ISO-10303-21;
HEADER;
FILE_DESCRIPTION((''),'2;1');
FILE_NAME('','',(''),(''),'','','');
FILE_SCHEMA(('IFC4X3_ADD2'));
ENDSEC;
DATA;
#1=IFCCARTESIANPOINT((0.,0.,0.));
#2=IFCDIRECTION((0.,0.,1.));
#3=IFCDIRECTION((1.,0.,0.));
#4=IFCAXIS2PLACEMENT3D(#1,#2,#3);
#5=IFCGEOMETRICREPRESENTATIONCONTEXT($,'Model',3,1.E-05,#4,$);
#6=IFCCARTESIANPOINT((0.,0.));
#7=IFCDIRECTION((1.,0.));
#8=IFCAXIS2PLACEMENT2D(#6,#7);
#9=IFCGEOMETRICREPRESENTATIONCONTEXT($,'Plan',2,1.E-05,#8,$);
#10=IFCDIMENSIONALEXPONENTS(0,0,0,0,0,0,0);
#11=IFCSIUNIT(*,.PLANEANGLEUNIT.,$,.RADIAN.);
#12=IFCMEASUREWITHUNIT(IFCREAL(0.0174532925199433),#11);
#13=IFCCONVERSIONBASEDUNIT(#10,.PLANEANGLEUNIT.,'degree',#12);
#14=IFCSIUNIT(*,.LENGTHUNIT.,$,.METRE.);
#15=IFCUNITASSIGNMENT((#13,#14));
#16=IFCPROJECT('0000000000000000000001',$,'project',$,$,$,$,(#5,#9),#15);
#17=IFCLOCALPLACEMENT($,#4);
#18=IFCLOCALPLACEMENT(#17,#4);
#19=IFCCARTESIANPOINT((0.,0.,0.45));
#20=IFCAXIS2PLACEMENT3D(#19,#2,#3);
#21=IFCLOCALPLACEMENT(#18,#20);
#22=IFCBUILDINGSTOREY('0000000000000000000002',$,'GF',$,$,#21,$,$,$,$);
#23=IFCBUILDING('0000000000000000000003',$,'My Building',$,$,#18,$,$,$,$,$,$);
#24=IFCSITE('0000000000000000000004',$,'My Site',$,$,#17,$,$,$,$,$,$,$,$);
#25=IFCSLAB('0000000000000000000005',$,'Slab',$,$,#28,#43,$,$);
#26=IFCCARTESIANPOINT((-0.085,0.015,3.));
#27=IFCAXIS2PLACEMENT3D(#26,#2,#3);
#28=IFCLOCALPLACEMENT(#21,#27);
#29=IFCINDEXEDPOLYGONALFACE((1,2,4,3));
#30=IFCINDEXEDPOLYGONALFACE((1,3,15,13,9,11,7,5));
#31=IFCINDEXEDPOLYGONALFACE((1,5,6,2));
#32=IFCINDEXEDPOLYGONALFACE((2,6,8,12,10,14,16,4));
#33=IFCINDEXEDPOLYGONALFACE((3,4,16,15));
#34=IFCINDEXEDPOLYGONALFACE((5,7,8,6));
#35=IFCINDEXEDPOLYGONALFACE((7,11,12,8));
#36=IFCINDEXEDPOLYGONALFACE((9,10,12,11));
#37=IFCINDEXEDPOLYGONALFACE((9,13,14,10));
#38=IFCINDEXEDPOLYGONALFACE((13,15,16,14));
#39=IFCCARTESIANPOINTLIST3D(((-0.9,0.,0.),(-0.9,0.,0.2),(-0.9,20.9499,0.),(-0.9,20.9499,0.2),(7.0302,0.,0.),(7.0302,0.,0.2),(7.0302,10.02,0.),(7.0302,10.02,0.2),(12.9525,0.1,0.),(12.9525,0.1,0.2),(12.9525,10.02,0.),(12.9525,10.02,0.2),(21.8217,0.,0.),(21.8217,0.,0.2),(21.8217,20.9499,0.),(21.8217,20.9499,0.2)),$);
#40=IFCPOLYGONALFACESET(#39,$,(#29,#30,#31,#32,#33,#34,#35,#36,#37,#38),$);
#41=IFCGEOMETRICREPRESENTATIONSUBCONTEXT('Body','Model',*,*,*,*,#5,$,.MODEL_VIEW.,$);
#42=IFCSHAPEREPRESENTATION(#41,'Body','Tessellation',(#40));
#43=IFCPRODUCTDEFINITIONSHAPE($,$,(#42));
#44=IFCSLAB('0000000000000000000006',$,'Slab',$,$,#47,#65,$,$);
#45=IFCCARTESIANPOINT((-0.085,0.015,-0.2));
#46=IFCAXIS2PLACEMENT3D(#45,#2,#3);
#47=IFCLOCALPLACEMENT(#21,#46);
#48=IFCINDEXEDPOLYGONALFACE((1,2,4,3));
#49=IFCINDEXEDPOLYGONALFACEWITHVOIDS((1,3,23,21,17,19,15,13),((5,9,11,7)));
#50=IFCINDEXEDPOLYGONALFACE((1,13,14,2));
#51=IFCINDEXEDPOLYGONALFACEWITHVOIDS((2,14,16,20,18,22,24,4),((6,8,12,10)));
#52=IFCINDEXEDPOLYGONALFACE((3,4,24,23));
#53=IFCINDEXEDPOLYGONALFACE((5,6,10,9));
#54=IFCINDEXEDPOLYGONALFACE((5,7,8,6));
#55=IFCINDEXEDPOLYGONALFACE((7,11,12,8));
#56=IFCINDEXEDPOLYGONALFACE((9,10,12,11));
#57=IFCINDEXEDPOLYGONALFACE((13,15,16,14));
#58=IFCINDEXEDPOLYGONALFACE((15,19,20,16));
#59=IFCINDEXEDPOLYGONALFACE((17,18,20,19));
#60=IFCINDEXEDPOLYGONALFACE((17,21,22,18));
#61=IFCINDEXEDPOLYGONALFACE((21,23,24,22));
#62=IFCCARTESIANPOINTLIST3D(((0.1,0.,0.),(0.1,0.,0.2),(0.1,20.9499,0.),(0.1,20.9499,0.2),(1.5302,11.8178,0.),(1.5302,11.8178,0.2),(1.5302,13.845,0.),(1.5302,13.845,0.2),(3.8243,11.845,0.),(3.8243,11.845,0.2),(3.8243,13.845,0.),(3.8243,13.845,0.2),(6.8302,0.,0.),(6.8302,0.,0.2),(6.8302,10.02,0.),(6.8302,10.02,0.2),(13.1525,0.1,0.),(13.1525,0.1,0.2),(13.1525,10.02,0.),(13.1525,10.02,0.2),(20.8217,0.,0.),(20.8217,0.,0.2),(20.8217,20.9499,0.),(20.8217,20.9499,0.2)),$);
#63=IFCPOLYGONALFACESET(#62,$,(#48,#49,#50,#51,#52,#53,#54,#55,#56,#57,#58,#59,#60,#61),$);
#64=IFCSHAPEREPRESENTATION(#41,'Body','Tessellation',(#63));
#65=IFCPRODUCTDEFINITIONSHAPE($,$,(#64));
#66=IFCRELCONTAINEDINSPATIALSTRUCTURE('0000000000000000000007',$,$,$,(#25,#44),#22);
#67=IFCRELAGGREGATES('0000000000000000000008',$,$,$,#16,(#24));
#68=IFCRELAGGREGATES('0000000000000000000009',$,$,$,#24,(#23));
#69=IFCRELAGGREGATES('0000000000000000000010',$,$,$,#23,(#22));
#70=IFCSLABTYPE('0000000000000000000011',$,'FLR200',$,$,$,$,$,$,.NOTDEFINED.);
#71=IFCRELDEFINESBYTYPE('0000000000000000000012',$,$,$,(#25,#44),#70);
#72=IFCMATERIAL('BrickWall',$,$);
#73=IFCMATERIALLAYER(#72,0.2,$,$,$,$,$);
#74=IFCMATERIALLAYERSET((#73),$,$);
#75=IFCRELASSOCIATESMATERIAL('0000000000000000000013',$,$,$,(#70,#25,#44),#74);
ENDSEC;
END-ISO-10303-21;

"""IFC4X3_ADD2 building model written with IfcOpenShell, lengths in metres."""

from ifc_helpers import new_model, entity, si_unit, converted_unit, frame, origin_with_axes, origin_2d_with_axis, place, context, subcontext, project, spatial, line, indexed_curve, outline, extrude, material, layer, layer_set, layer_usage, type_object, element, save


model = new_model("IFC4X3_ADD2")

# Units and contexts
model_context = context("Model", 3, precision=1e-05, world=origin_with_axes())
plan_context = context("Plan", 2, precision=1e-05, world=origin_2d_with_axis())
body_context_1 = subcontext(model_context, "Body", "Model", "MODEL_VIEW")
ifc_project = project(units=[converted_unit("PLANEANGLEUNIT", "degree", entity("IfcReal", 0.0174532925199433), si_unit("PLANEANGLEUNIT", "RADIAN"), dimensions=[0, 0, 0, 0, 0, 0, 0]), si_unit("LENGTHUNIT", "METRE")], contexts=[model_context, plan_context])

# Site, building, storey
site_placement = place(None, origin_with_axes())
site = spatial("IfcSite", under=ifc_project, at=site_placement, Name="My Site")
building_placement = place(site_placement, origin_with_axes())
building = spatial("IfcBuilding", under=site, at=building_placement, Name="My Building")
storey_placement = place(building_placement, frame((0.0, 0.0, 0.45), z_axis=(0.0, 0.0, 1.0), x_axis=(1.0, 0.0, 0.0)))
storey = spatial("IfcBuildingStorey", under=building, at=storey_placement, Name="GF")

# Slabs
ifc_material_1 = material(Name="BrickWall")
ifc_layer_1 = layer(ifc_material_1, 0.2)
ifc_layer_set_1 = layer_set([ifc_layer_1])
ifc_layer_usage_1 = layer_usage(ifc_layer_set_1, "AXIS3", "POSITIVE", 0.0)
slab_type = type_object("IfcSlabType", Name="FLR200", PredefinedType="NOTDEFINED", material=ifc_layer_set_1)
slab_1_placement = place(storey_placement, frame((-0.085, 0.015, 3.0), z_axis=(0.0, 0.0, 1.0), x_axis=(1.0, 0.0, 0.0)))
element("IfcSlab", 1, at=slab_1_placement, inside=storey, type_object=slab_type, material=ifc_layer_usage_1, Name="Slab", context=body_context_1, shape_type="SweptSolid", body=[
    extrude(outline(indexed_curve([(-0.9, 0.0), (7.0302, 0.0), (7.0302, 10.02), (12.9525, 10.02), (12.9525, 0.1), (21.8217, 0.0), (21.8217, 20.9499), (-0.9, 20.9499)], segments=[line(5, 4), line(4, 3), line(3, 2), line(2, 1), line(1, 8), line(8, 7), line(7, 6), line(6, 5)], self_intersect=False)), None, (0.0, 0.0, 1.0), 0.2),
])
ifc_layer_usage_2 = layer_usage(ifc_layer_set_1, "AXIS3", "POSITIVE", 0.0)
slab_2_placement = place(storey_placement, frame((-0.085, 0.015, -0.2), z_axis=(0.0, 0.0, 1.0), x_axis=(1.0, 0.0, 0.0)))
element("IfcSlab", 2, at=slab_2_placement, inside=storey, type_object=slab_type, material=ifc_layer_usage_2, Name="Slab", context=body_context_1, shape_type="SweptSolid", body=[
    extrude(outline(indexed_curve([(6.8302, 10.02), (13.1525, 10.02), (13.1525, 0.1), (20.8217, 0.0), (20.8217, 20.9499), (0.1, 20.9499), (0.1, 0.0), (6.8302, 0.0), (3.8243, 11.845), (1.5302, 11.8178), (1.5302, 13.845), (3.8243, 13.845)], segments=[line(8, 7), line(7, 6), line(6, 5), line(5, 4), line(4, 3), line(3, 2), line(2, 1), line(1, 8)], self_intersect=False), holes=[indexed_curve([(6.8302, 10.02), (13.1525, 10.02), (13.1525, 0.1), (20.8217, 0.0), (20.8217, 20.9499), (0.1, 20.9499), (0.1, 0.0), (6.8302, 0.0), (3.8243, 11.845), (1.5302, 11.8178), (1.5302, 13.845), (3.8243, 13.845)], segments=[line(9, 12), line(12, 11), line(11, 10), line(10, 9)], self_intersect=False)]), None, (0.0, 0.0, 1.0), 0.2),
])

save(model, "model.ifc")
